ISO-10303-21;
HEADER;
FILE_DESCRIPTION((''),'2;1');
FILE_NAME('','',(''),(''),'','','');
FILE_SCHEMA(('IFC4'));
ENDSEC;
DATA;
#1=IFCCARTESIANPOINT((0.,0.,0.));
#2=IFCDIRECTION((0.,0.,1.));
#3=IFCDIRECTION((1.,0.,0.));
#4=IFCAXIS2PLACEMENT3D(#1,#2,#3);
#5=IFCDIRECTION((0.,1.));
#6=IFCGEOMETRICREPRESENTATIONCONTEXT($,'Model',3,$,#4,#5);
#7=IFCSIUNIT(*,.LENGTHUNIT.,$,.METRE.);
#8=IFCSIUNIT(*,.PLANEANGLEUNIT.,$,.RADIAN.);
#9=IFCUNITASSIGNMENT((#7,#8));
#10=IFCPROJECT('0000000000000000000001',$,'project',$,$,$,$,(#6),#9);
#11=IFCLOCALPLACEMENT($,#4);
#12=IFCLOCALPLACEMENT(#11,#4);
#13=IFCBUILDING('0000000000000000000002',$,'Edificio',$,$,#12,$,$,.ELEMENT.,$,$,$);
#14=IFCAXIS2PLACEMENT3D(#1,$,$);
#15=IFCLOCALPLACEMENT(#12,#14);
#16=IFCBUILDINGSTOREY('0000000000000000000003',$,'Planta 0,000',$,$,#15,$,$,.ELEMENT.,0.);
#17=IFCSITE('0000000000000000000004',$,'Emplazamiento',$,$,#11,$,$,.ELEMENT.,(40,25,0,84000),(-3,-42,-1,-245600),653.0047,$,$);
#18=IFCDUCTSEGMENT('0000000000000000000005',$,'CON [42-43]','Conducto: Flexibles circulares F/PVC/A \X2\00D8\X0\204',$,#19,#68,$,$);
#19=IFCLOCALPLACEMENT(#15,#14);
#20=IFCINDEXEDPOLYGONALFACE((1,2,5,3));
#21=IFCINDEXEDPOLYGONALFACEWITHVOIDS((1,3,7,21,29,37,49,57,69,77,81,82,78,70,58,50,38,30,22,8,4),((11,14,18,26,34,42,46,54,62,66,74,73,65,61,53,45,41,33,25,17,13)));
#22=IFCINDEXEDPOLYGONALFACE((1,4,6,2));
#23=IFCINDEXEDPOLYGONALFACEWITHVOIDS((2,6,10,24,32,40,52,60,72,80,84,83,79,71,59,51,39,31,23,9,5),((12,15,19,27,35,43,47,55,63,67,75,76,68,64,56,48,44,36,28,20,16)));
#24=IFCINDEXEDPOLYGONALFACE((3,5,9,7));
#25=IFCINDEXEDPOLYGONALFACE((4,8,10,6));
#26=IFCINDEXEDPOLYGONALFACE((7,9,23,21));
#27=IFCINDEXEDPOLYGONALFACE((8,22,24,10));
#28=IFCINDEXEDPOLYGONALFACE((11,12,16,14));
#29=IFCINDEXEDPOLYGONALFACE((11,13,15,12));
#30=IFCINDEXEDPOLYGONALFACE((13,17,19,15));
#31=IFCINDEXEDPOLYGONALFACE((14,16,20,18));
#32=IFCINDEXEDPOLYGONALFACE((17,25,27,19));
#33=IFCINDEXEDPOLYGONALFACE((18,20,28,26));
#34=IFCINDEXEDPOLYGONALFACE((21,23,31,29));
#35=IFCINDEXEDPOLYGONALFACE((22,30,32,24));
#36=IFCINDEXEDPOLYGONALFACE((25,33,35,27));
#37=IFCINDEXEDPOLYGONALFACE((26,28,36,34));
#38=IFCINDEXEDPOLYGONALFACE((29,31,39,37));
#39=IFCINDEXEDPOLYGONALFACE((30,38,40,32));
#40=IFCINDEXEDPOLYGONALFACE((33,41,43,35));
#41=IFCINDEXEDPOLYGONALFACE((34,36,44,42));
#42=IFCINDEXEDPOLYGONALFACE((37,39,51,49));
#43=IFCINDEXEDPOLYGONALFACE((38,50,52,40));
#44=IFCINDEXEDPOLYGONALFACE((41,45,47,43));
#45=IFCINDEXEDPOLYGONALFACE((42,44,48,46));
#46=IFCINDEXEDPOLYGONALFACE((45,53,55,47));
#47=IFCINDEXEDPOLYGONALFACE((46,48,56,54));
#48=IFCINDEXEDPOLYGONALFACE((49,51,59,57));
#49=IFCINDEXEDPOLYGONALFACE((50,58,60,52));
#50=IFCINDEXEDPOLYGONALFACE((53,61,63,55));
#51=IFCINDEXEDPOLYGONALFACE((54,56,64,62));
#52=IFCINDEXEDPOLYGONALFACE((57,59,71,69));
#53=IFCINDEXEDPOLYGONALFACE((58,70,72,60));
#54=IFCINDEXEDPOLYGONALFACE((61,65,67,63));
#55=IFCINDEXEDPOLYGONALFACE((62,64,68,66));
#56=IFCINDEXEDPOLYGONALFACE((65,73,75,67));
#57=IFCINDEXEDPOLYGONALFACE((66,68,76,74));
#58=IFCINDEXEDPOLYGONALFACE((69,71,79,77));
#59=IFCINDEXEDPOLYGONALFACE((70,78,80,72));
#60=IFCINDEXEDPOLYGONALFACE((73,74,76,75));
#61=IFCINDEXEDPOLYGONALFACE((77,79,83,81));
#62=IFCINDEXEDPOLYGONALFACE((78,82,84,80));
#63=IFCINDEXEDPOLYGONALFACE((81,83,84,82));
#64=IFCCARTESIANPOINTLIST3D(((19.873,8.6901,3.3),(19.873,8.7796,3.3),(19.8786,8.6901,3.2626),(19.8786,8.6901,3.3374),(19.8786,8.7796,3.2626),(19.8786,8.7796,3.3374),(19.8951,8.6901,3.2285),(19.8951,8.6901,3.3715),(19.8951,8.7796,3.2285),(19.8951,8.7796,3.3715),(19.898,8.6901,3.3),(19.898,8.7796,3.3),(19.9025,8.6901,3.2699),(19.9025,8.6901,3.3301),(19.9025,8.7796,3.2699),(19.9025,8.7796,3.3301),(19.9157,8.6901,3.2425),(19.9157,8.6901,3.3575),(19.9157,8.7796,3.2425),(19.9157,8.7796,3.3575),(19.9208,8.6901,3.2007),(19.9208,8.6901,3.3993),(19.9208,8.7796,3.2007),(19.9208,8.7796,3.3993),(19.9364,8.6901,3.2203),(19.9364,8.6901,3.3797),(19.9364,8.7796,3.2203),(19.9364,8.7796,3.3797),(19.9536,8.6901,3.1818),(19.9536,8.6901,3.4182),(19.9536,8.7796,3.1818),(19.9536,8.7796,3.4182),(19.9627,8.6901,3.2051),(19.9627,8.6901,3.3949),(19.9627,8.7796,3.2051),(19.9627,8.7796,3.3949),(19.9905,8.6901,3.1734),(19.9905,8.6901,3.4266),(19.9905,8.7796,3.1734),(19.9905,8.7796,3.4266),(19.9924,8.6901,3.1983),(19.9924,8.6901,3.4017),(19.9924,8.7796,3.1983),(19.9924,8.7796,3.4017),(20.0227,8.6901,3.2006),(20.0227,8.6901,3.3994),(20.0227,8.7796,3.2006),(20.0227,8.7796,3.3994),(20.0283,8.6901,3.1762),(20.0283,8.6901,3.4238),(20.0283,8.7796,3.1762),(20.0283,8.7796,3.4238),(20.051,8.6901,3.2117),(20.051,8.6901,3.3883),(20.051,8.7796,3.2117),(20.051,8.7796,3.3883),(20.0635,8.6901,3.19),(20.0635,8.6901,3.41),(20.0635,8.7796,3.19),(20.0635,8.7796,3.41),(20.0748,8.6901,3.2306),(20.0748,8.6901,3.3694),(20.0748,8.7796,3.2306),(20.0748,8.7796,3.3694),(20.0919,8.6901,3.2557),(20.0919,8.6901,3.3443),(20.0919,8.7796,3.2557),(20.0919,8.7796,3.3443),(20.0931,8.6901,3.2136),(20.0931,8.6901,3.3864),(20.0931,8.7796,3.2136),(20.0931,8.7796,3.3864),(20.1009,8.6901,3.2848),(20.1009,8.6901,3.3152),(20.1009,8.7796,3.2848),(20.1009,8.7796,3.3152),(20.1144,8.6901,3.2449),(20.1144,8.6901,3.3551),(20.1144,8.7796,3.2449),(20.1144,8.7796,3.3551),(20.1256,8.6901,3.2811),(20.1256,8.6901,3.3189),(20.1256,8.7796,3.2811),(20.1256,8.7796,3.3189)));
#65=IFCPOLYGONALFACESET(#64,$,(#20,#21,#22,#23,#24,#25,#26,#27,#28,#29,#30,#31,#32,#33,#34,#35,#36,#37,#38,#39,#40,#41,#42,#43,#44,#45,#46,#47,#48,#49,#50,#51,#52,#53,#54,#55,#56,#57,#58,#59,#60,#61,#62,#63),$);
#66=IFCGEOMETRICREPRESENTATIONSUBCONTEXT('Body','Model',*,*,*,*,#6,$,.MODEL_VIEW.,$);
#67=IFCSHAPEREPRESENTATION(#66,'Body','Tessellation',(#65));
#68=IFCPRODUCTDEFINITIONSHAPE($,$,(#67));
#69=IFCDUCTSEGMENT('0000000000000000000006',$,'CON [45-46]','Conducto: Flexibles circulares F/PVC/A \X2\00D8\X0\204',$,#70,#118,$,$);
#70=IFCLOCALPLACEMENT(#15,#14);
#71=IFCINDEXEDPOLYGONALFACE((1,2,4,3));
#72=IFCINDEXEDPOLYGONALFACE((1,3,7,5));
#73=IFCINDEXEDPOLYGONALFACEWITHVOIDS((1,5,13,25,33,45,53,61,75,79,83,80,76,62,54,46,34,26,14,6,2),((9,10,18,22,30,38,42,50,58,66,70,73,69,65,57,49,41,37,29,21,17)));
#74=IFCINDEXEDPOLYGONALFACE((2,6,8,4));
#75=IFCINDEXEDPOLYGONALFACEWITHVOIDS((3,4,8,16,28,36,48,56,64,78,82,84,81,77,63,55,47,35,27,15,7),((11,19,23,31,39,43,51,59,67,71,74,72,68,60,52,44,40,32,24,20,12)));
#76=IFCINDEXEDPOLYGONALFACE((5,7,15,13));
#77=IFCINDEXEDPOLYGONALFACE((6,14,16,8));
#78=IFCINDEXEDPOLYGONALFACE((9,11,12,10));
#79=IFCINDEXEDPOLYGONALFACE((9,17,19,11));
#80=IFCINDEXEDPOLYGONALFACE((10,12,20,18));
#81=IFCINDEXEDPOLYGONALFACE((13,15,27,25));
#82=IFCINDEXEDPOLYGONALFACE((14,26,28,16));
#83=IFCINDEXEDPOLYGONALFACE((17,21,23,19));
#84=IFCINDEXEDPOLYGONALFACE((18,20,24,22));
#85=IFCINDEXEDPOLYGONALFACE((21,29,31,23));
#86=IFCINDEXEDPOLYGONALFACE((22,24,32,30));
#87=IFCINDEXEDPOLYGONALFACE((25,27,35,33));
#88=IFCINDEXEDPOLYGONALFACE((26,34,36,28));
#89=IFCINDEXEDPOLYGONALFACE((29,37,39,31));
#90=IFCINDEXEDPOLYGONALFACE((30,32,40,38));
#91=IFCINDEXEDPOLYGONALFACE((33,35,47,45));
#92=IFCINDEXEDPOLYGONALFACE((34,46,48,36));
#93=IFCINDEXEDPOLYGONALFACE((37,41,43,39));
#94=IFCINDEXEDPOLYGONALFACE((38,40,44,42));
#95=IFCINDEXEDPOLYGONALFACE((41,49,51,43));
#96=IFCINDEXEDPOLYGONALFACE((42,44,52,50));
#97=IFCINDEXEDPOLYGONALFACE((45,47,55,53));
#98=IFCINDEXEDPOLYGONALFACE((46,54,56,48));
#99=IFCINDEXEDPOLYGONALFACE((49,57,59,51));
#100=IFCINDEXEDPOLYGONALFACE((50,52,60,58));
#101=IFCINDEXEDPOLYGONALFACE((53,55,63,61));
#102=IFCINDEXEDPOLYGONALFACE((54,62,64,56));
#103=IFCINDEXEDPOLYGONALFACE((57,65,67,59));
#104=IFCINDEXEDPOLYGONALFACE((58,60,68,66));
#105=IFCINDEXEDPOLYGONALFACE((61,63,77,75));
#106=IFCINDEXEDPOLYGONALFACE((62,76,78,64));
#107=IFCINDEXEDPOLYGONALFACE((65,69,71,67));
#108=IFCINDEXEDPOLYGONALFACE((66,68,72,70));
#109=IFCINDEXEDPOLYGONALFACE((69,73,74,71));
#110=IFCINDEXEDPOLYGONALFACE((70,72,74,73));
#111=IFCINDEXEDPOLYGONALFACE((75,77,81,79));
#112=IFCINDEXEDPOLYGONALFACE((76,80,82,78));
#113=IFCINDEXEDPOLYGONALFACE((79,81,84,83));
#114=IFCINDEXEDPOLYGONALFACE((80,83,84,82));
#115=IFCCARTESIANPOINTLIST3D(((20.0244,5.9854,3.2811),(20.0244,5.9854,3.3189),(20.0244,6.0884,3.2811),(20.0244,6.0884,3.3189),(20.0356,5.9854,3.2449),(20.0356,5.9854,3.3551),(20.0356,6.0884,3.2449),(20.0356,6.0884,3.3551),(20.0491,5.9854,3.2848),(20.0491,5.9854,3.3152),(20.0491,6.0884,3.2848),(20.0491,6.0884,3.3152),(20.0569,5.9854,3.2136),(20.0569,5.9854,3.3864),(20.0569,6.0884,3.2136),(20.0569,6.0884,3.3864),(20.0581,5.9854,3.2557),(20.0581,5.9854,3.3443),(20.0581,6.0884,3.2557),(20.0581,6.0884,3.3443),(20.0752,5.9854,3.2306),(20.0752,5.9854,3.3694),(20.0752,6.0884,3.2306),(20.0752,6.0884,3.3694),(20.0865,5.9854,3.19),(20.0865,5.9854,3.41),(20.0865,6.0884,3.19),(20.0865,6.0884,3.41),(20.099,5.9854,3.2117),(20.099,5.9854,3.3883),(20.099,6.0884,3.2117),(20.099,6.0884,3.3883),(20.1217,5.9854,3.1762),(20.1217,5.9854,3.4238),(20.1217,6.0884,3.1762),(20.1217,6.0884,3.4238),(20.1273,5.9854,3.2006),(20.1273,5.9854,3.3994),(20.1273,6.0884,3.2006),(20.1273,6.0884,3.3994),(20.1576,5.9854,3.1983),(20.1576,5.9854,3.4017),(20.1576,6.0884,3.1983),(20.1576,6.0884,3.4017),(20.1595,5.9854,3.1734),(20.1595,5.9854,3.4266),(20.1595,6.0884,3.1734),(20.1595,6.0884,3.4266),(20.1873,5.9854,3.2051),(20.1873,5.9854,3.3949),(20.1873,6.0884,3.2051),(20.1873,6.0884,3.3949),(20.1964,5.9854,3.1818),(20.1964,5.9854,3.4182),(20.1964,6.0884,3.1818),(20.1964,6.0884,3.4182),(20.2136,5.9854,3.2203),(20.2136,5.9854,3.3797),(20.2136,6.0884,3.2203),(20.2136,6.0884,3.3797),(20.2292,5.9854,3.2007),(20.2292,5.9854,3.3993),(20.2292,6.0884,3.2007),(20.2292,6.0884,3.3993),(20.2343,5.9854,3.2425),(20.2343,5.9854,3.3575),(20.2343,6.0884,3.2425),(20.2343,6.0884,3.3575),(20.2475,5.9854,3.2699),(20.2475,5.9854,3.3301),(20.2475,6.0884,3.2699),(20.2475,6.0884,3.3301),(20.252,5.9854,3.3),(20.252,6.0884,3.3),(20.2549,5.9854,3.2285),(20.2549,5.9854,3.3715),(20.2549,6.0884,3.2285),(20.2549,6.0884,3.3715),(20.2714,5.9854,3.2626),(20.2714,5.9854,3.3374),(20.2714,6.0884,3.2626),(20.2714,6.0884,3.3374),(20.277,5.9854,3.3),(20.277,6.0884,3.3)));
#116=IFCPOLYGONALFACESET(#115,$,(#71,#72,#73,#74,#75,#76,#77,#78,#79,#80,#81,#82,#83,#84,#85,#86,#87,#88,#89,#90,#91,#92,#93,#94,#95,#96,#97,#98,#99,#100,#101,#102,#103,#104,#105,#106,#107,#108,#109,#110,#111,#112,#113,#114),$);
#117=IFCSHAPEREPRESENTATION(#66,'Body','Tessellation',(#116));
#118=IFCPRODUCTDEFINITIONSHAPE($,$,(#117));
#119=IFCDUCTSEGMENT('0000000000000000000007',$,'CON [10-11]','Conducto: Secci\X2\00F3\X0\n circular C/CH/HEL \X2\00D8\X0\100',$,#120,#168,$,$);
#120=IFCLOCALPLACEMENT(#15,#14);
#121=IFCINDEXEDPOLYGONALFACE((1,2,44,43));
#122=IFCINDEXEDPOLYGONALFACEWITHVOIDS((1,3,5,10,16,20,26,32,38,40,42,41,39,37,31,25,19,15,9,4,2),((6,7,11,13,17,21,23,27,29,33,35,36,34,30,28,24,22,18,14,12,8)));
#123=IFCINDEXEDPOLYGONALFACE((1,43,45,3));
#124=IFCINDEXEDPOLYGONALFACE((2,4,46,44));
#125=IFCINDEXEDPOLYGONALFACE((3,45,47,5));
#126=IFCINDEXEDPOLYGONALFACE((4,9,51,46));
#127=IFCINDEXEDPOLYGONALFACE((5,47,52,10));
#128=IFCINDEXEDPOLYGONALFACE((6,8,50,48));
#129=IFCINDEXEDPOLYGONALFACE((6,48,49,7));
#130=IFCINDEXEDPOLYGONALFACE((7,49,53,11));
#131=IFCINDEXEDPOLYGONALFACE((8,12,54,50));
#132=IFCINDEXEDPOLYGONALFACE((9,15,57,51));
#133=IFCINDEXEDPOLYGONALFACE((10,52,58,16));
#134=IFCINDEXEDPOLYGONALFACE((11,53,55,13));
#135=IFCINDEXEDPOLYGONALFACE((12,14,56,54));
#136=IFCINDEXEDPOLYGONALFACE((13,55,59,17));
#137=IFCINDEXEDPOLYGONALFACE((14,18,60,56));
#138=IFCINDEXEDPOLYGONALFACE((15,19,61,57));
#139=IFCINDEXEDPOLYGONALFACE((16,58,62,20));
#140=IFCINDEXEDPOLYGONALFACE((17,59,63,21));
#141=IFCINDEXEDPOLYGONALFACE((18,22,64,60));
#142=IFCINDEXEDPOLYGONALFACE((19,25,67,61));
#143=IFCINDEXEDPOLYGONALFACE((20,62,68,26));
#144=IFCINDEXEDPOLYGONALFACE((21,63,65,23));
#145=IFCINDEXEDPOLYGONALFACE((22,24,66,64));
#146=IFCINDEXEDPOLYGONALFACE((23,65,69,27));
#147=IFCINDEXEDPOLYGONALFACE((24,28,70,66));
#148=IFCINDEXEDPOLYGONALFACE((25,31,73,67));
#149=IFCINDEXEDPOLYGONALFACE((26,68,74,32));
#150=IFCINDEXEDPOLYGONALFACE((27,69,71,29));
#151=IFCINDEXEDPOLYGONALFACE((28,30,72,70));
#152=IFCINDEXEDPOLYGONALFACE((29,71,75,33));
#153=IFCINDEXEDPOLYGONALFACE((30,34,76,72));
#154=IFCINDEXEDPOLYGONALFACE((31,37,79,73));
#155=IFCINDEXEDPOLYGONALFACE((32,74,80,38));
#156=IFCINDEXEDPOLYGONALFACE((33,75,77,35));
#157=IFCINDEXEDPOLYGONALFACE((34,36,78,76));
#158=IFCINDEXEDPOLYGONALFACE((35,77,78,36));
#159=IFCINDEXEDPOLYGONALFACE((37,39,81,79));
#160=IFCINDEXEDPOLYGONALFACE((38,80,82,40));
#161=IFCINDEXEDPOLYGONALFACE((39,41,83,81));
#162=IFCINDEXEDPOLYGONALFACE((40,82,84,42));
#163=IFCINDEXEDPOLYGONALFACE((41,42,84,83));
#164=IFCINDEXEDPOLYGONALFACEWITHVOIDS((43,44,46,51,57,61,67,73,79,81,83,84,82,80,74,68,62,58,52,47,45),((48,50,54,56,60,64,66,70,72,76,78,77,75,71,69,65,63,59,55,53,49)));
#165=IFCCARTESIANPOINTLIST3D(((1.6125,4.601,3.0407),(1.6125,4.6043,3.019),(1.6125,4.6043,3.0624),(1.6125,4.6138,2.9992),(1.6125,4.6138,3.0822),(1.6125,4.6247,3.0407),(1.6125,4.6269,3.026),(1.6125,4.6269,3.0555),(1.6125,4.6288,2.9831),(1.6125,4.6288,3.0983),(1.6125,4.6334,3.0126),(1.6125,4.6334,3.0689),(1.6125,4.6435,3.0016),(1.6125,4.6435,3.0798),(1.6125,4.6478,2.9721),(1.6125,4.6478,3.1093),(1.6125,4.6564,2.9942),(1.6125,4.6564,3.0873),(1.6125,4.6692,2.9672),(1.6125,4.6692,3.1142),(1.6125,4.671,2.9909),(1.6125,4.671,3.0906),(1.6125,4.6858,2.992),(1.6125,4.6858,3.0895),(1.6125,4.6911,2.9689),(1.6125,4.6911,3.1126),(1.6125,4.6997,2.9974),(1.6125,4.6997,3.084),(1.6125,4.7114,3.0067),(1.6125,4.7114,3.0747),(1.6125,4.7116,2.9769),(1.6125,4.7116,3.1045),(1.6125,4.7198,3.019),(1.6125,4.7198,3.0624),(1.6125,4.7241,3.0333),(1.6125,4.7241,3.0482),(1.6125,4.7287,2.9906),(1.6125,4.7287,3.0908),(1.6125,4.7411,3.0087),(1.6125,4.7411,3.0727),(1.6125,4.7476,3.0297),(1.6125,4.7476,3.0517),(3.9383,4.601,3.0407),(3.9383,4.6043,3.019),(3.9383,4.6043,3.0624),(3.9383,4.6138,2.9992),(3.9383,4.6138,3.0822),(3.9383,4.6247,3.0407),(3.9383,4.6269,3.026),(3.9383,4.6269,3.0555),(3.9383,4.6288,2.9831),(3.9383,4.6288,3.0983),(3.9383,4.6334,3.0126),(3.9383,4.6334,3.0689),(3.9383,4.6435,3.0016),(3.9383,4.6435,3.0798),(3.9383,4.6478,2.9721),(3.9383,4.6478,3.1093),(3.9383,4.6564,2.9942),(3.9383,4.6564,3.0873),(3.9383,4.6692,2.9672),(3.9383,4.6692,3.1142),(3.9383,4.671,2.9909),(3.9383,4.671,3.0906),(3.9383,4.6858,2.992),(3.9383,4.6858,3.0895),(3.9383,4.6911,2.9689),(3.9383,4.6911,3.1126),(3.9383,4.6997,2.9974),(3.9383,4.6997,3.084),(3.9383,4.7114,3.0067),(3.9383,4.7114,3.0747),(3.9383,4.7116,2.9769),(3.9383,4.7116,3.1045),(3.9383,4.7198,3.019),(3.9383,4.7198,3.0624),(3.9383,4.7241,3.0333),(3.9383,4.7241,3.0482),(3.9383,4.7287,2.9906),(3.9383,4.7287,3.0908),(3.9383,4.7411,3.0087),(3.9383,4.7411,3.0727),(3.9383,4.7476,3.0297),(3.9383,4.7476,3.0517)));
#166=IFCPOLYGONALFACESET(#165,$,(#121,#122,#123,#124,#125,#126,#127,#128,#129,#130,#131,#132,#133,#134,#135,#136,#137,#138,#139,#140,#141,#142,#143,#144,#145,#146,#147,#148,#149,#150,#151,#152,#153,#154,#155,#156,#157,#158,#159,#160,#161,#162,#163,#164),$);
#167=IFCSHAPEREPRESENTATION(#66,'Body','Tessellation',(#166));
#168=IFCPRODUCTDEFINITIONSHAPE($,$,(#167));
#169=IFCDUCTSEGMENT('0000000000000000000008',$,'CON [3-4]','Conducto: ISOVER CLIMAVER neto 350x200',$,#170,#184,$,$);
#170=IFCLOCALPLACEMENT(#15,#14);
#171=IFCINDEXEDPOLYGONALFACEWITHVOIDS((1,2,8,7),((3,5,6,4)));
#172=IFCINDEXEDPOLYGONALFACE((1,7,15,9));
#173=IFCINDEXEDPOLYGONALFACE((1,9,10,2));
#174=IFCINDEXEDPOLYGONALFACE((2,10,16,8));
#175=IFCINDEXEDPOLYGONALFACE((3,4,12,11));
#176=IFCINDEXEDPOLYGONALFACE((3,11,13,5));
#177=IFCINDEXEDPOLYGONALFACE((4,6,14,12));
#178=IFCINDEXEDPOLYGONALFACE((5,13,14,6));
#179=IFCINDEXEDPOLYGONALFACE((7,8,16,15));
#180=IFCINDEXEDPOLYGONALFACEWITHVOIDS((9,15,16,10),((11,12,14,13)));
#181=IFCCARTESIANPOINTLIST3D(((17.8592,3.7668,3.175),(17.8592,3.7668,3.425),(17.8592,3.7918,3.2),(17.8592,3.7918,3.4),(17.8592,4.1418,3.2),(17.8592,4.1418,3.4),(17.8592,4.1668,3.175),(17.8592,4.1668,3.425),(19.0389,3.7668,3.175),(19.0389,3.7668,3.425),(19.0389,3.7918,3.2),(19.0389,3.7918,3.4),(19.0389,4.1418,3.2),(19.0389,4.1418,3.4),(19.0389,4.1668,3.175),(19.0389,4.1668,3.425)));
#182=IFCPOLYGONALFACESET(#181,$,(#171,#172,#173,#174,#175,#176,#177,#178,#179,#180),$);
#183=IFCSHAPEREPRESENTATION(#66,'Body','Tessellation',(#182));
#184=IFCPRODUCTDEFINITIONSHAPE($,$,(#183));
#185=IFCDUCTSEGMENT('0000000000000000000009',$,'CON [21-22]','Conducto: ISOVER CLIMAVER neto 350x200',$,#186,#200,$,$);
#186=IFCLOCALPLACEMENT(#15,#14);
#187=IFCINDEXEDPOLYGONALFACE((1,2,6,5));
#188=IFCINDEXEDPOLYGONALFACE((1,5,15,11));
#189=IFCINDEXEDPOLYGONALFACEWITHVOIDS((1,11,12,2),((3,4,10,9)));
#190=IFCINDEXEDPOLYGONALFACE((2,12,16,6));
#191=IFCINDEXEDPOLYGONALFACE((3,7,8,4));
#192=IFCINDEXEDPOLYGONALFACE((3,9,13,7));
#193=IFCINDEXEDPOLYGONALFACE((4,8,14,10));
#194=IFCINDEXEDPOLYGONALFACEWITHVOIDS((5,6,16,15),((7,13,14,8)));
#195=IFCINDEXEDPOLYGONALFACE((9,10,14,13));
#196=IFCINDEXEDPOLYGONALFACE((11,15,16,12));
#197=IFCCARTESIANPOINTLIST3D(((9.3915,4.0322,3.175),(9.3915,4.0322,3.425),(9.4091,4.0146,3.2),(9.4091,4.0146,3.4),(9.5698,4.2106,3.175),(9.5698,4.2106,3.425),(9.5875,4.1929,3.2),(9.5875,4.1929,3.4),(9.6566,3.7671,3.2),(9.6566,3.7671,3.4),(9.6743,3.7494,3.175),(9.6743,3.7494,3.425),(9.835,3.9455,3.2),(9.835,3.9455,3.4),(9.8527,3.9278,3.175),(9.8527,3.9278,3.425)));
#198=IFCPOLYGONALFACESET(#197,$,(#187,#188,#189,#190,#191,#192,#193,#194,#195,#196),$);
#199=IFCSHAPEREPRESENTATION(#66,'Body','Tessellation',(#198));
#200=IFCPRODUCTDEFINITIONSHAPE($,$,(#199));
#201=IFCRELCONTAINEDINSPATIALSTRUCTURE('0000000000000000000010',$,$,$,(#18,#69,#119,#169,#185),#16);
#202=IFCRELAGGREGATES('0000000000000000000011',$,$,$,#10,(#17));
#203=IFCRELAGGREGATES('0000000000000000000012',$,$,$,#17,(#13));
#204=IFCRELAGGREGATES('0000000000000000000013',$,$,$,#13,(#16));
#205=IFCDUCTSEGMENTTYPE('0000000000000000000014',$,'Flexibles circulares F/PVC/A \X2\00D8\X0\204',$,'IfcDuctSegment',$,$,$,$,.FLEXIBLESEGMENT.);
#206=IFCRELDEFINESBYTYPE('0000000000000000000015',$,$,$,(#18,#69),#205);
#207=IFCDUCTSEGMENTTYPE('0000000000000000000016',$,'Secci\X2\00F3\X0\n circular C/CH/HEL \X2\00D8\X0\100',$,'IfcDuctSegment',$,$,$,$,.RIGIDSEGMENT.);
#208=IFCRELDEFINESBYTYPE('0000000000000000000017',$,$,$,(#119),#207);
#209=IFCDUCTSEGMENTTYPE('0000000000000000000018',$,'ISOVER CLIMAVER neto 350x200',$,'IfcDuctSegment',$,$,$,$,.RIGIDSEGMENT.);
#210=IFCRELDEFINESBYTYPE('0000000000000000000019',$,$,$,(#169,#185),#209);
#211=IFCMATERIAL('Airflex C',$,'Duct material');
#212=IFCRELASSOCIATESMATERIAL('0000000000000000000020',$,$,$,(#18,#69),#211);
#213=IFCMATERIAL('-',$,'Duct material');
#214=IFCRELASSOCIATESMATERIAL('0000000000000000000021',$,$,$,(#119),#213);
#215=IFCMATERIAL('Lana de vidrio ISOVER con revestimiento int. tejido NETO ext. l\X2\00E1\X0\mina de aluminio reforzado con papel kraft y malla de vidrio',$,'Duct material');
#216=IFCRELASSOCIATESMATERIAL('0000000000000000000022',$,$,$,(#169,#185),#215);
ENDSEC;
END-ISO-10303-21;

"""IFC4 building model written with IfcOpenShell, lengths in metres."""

from ifc_helpers import new_model, si_unit, direction, frame, origin, origin_with_axes, origin_2d_with_axis, place, context, subcontext, project, spatial, hollow_rectangle, hollow_circle, extrude, material, type_object, element, save


model = new_model("IFC4")

# Units and contexts
model_context = context("Model", 3, world=origin_with_axes(), true_north=direction((0.0, 1.0)))
body_context = subcontext(model_context, "Body", "Model", "MODEL_VIEW")
ifc_project = project(units=[si_unit("LENGTHUNIT", "METRE"), si_unit("PLANEANGLEUNIT", "RADIAN")], contexts=[model_context])

# Site, building, storey
site_placement = place(None, origin_with_axes())
site = spatial("IfcSite", under=ifc_project, at=site_placement, Name="Emplazamiento", CompositionType="ELEMENT", RefLatitude=(40, 25, 0, 84000), RefLongitude=(-3, -42, -1, -245600), RefElevation=653.0047)
building_placement = place(site_placement, origin_with_axes())
building = spatial("IfcBuilding", under=site, at=building_placement, Name="Edificio", CompositionType="ELEMENT")
storey_placement = place(building_placement, origin())
storey = spatial("IfcBuildingStorey", under=building, at=storey_placement, Name="Planta 0,000", CompositionType="ELEMENT", Elevation=0.0)

# Shared definitions
ifc_material_1 = material(Name="Lana de vidrio ISOVER con revestimiento int. tejido NETO ext. lámina de aluminio reforzado con papel kraft y malla de vidrio", Category="Duct material")
ifc_material_2 = material(Name="Airflex C", Category="Duct material")
ifc_material_3 = material(Name="-", Category="Duct material")

# Duct segments
duct_segment_type_1 = type_object("IfcDuctSegmentType", Name="Flexibles circulares F/PVC/A Ø204", ApplicableOccurrence="IfcDuctSegment", PredefinedType="FLEXIBLESEGMENT")
duct_segment_1_placement = place(storey_placement, origin_with_axes())
element("IfcDuctSegment", 1, at=duct_segment_1_placement, inside=storey, type_object=duct_segment_type_1, material=ifc_material_2, Name="CON [42-43]", Description="Conducto: Flexibles circulares F/PVC/A Ø204", context=body_context, shape_type="SweptSolid", body=[
    extrude(hollow_circle(Radius=0.127, WallThickness=0.025, at=origin_2d_with_axis()), frame((20.0, 8.6901, 3.3), z_axis=(0.0, 1.0, 0.0), x_axis=(-1.0, 0.0, 0.0)), (0.0, 0.0, 1.0), 0.0895),
])
duct_segment_2_placement = place(storey_placement, origin_with_axes())
element("IfcDuctSegment", 2, at=duct_segment_2_placement, inside=storey, type_object=duct_segment_type_1, material=ifc_material_2, Name="CON [45-46]", Description="Conducto: Flexibles circulares F/PVC/A Ø204", context=body_context, shape_type="SweptSolid", body=[
    extrude(hollow_circle(Radius=0.127, WallThickness=0.025, at=origin_2d_with_axis()), frame((20.15, 6.0884, 3.3), z_axis=(0.0, -1.0, 0.0), x_axis=(1.0, 0.0, 0.0)), (0.0, 0.0, 1.0), 0.103),
])
duct_segment_type_2 = type_object("IfcDuctSegmentType", Name="Sección circular C/CH/HEL Ø100", ApplicableOccurrence="IfcDuctSegment", PredefinedType="RIGIDSEGMENT")
duct_segment_3_placement = place(storey_placement, origin_with_axes())
element("IfcDuctSegment", 3, at=duct_segment_3_placement, inside=storey, type_object=duct_segment_type_2, material=ifc_material_3, Name="CON [10-11]", Description="Conducto: Sección circular C/CH/HEL Ø100", context=body_context, shape_type="SweptSolid", body=[
    extrude(hollow_circle(Radius=0.0737, WallThickness=0.0237, at=origin_2d_with_axis()), frame((3.9383, 4.6747, 3.0407), z_axis=(-1.0, 0.0, 0.0), x_axis=(0.0, -1.0, 0.0)), (0.0, 0.0, 1.0), 2.3258),
])

# Duct segments
duct_segment_type_3 = type_object("IfcDuctSegmentType", Name="ISOVER CLIMAVER neto 350x200", ApplicableOccurrence="IfcDuctSegment", PredefinedType="RIGIDSEGMENT")
duct_segment_4_placement = place(storey_placement, origin_with_axes())
element("IfcDuctSegment", 4, at=duct_segment_4_placement, inside=storey, type_object=duct_segment_type_3, material=ifc_material_1, Name="CON [3-4]", Description="Conducto: ISOVER CLIMAVER neto 350x200", context=body_context, shape_type="SweptSolid", body=[
    extrude(hollow_rectangle(XDim=0.4, YDim=0.25, WallThickness=0.025, at=origin_2d_with_axis()), frame((17.8592, 3.9668, 3.3), z_axis=(1.0, 0.0, 0.0), x_axis=(0.0, 1.0, 0.0)), (0.0, 0.0, 1.0), 1.1797),
])
duct_segment_5_placement = place(storey_placement, origin_with_axes())
element("IfcDuctSegment", 5, at=duct_segment_5_placement, inside=storey, type_object=duct_segment_type_3, material=ifc_material_1, Name="CON [21-22]", Description="Conducto: ISOVER CLIMAVER neto 350x200", context=body_context, shape_type="SweptSolid", body=[
    extrude(hollow_rectangle(XDim=0.4, YDim=0.25, WallThickness=0.025, at=origin_2d_with_axis()), frame((9.7112, 4.0692, 3.3), z_axis=(-0.707107, -0.707107, 0.0), x_axis=(0.707107, -0.707107, 0.0)), (0.0, 0.0, 1.0), 0.2523),
])

save(model, "model.ifc")
